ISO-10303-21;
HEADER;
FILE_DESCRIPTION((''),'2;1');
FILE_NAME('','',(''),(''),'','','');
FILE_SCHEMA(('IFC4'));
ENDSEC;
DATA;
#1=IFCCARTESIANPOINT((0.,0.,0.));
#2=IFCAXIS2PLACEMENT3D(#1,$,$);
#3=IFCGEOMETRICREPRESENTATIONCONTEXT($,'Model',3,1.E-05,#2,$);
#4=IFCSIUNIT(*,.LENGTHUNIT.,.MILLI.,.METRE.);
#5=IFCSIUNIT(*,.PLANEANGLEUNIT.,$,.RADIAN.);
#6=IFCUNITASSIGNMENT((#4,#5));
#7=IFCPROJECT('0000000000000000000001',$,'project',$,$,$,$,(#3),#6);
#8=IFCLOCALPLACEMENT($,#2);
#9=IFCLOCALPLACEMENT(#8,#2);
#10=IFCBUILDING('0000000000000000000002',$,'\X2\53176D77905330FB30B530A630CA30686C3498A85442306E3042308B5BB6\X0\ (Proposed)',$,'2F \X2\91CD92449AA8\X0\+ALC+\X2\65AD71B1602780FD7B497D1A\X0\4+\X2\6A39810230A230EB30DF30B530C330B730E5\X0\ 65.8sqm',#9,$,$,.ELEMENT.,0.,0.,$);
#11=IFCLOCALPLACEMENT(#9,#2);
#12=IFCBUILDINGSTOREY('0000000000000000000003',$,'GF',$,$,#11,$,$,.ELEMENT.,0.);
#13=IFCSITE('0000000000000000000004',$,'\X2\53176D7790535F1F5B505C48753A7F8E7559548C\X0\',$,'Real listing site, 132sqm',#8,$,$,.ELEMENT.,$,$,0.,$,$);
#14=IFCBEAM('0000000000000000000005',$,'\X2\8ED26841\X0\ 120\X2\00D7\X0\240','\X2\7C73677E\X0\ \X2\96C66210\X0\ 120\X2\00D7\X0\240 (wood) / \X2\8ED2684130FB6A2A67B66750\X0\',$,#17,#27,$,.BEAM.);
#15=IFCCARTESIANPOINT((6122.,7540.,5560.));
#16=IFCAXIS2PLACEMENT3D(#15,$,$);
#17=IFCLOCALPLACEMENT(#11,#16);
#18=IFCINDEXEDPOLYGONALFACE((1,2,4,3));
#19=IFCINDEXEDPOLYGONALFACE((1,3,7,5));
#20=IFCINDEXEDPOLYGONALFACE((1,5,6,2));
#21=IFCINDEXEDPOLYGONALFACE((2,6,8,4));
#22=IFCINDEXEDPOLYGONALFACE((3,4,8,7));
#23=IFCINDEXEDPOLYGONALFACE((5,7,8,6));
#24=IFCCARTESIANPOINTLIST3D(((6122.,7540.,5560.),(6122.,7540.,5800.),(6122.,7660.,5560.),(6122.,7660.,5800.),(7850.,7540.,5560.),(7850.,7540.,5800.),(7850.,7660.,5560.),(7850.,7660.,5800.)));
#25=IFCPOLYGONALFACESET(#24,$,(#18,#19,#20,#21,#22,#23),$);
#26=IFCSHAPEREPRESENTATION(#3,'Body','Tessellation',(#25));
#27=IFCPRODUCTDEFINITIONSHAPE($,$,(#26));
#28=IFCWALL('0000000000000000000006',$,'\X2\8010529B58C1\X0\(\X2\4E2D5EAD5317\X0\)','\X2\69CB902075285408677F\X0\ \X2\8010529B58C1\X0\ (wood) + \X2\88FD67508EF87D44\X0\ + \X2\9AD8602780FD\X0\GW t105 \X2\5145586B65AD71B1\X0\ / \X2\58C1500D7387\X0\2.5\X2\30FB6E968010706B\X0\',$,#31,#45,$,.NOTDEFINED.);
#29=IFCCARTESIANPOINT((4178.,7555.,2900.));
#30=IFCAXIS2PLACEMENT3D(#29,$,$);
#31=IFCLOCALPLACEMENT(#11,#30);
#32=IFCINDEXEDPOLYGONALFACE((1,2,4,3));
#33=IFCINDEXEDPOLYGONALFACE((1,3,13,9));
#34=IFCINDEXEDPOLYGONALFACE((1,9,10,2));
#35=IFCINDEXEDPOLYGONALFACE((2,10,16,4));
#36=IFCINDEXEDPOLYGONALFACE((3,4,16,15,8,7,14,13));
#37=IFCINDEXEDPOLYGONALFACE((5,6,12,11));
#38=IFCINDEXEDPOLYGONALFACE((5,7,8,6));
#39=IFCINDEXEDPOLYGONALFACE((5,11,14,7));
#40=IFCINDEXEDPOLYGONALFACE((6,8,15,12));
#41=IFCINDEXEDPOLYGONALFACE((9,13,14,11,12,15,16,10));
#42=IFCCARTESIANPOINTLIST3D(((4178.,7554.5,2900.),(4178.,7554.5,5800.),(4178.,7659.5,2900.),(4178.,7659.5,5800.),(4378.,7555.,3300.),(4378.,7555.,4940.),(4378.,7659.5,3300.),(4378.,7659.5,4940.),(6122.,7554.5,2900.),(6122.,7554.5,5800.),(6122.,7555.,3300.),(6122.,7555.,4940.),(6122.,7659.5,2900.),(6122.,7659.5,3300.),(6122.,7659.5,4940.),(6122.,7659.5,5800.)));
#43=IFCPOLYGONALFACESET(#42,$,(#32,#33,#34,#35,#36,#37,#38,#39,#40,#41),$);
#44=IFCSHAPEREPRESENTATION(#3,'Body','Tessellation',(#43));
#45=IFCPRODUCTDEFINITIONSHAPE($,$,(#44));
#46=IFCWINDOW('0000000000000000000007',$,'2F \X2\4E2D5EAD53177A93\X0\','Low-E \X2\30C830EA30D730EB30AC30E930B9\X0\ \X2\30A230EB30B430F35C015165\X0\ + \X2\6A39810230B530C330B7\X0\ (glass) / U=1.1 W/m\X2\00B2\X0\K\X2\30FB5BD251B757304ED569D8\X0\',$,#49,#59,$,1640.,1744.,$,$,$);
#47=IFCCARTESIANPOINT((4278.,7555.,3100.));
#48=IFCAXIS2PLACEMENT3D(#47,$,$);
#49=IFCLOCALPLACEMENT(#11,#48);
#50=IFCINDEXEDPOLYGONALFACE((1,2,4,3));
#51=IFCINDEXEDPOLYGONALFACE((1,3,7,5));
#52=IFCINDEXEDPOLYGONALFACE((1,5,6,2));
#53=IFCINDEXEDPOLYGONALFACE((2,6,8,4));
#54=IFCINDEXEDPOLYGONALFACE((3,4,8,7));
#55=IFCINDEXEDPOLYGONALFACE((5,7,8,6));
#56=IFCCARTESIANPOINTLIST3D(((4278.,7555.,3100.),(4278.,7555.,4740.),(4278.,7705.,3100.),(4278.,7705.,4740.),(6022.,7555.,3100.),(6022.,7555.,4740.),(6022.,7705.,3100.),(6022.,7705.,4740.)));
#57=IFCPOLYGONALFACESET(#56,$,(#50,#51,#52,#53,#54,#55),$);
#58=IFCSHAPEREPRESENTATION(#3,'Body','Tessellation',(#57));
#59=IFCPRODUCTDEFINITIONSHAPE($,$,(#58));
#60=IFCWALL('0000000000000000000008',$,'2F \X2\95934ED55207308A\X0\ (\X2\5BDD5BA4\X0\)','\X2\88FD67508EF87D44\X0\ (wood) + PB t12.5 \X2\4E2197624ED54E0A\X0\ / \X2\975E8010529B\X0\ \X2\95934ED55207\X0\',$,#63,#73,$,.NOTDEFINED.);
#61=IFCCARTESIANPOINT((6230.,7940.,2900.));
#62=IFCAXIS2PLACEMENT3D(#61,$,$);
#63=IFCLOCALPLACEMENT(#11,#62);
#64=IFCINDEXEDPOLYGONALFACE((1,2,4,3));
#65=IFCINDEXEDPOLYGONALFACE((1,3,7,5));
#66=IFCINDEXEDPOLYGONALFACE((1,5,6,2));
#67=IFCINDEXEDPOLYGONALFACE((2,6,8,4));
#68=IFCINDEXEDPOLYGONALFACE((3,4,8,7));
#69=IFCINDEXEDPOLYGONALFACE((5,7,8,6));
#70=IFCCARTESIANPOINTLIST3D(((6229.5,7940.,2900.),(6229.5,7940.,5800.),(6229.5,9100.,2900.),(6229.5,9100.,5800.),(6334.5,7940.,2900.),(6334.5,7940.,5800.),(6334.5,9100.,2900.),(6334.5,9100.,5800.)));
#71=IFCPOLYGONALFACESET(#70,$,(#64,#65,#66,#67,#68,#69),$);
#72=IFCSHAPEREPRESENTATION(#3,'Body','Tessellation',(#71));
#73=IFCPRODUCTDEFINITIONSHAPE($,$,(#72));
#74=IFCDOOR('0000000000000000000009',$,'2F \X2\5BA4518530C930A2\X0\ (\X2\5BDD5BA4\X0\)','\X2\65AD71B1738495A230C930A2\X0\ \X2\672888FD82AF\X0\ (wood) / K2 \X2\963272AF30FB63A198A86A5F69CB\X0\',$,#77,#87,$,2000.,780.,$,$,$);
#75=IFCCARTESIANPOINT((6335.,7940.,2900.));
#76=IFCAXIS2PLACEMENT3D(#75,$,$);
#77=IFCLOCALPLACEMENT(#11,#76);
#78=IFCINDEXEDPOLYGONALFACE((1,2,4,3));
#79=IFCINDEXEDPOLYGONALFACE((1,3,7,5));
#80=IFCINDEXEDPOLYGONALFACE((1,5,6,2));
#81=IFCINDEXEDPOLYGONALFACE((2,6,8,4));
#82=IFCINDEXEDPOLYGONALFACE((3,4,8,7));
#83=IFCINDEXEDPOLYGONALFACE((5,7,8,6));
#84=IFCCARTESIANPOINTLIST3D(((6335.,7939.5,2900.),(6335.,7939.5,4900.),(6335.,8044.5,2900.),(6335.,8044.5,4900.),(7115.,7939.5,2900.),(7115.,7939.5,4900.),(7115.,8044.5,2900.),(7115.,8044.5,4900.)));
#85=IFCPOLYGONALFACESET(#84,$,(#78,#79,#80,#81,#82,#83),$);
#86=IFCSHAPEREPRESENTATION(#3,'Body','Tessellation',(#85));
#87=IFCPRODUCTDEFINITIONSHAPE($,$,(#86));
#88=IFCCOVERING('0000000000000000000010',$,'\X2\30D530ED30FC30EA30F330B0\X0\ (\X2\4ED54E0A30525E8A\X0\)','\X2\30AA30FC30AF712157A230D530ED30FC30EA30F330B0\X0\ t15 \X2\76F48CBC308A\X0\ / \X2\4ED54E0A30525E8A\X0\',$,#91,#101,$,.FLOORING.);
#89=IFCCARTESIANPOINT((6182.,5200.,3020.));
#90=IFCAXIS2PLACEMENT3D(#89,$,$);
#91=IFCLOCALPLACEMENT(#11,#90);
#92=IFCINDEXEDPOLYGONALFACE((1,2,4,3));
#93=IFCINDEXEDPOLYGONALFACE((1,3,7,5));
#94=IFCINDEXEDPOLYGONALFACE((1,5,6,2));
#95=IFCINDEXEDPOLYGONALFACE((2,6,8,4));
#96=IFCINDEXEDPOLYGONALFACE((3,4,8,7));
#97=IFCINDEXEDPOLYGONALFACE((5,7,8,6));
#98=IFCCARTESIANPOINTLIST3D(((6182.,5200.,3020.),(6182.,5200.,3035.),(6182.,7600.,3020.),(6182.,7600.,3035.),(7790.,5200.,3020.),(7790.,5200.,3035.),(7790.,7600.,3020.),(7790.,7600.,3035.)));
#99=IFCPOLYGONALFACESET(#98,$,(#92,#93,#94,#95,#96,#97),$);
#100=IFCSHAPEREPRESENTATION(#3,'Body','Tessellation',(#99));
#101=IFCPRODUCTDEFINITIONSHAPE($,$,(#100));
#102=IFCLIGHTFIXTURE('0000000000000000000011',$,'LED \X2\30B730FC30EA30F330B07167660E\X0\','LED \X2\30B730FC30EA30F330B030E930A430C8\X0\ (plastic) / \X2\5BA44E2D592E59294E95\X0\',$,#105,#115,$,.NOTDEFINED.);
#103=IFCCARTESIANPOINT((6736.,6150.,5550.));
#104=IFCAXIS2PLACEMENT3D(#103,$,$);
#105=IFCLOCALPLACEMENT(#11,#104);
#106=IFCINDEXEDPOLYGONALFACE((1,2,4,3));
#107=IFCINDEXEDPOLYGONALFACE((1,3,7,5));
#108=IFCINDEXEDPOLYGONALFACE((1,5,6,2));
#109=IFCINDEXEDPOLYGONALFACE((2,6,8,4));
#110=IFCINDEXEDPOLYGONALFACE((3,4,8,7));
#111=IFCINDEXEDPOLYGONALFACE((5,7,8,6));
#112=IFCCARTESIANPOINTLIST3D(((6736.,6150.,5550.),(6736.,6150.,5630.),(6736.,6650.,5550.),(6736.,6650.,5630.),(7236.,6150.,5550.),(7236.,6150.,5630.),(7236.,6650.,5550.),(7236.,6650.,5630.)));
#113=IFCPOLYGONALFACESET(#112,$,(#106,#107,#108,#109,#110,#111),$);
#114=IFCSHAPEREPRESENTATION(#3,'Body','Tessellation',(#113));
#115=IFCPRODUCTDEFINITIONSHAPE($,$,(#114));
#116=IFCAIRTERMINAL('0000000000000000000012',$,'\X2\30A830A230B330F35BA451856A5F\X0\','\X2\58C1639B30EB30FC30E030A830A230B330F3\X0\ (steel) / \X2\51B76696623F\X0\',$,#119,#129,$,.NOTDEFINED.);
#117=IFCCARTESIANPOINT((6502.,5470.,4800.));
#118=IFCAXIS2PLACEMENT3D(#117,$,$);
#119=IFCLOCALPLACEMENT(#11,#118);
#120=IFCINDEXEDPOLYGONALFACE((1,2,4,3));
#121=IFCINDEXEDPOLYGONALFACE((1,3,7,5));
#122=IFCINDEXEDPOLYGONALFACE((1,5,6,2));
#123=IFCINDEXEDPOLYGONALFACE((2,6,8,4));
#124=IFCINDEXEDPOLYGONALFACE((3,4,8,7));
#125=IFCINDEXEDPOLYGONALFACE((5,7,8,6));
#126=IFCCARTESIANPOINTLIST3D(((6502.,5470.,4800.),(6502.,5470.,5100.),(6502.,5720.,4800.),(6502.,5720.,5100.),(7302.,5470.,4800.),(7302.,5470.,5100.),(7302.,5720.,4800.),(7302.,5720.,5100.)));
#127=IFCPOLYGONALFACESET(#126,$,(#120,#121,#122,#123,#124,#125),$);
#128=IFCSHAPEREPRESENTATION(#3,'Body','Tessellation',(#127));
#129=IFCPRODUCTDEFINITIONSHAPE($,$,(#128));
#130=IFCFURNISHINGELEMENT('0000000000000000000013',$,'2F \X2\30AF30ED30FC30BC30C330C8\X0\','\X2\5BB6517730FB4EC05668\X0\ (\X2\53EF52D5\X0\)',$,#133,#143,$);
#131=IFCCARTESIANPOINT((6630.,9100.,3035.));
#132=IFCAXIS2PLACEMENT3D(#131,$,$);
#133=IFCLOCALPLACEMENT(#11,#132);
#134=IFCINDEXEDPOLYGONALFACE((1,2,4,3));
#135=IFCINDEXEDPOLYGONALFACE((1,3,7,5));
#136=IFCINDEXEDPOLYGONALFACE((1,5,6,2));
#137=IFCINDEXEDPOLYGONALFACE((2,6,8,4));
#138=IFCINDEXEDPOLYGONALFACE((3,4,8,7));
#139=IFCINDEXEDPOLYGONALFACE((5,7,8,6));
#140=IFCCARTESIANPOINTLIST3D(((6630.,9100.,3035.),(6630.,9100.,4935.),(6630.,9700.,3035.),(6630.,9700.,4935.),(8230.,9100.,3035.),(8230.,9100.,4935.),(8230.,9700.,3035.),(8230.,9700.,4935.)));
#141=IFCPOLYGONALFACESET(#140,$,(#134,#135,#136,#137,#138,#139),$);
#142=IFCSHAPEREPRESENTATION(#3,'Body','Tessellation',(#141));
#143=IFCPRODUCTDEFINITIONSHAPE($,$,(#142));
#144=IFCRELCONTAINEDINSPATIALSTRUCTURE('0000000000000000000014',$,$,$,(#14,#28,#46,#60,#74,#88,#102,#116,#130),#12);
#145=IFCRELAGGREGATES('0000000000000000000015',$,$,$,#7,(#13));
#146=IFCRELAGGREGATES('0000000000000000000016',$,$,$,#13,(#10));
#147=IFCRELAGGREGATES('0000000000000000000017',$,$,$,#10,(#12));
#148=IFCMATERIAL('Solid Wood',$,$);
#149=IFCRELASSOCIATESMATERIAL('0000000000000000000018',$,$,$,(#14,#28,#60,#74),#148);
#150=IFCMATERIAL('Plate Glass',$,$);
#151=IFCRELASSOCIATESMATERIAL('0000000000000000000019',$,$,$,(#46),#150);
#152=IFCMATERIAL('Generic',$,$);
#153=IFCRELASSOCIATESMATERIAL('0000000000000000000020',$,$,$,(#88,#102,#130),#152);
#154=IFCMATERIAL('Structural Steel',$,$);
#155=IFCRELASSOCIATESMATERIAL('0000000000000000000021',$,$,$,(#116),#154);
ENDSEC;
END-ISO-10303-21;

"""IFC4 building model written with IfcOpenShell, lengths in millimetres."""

from ifc_helpers import new_model, si_unit, frame, frame_2d, origin, place, context, project, spatial, rectangle, extrude, material, element, fill, save


model = new_model("IFC4")

# Units and contexts
model_context = context("Model", 3, precision=1e-05, world=origin())
ifc_project = project(units=[si_unit("LENGTHUNIT", "METRE", prefix="MILLI"), si_unit("PLANEANGLEUNIT", "RADIAN")], contexts=[model_context])

# Site, building, storey
site_placement = place(None, origin())
site = spatial("IfcSite", under=ifc_project, at=site_placement, Name="北海道弟子屈町美留和", ObjectType="Real listing site, 132sqm", CompositionType="ELEMENT", RefElevation=0.0)
building_placement = place(site_placement, origin())
building = spatial("IfcBuilding", under=site, at=building_placement, Name="北海道・サウナと水風呂のある家 (Proposed)", ObjectType="2F 重鉄骨+ALC+断熱性能等級4+樹脂アルミサッシュ 65.8sqm", CompositionType="ELEMENT", ElevationOfRefHeight=0.0, ElevationOfTerrain=0.0)
storey_placement = place(building_placement, origin())
storey = spatial("IfcBuildingStorey", under=building, at=storey_placement, Name="GF", CompositionType="ELEMENT", Elevation=0.0)

# Shared definitions
ifc_material_1 = material(Name="Solid Wood")

# Beam
beam_1_placement = place(storey_placement, frame((6122.0, 7540.0, 5560.0)))
element("IfcBeam", 1, at=beam_1_placement, inside=storey, material=ifc_material_1, Name="軒桁 120×240", Description="米松 集成 120×240 (wood) / 軒桁・横架材", PredefinedType="BEAM", context=model_context, shape_type="SweptSolid", body=[
    extrude(rectangle(XDim=1728.0, YDim=120.0, at=frame_2d((864.0, 60.0))), frame((6122.0, 7540.0, 5560.0)), (0.0, 0.0, 1.0), 240.0),
])

# Wall, opening, window
wall_1_placement = place(storey_placement, frame((4178.0, 7555.0, 2900.0)))
wall_1 = element("IfcWall", 2, at=wall_1_placement, inside=storey, material=ifc_material_1, Name="耐力壁(中庭北)", Description="構造用合板 耐力壁 (wood) + 製材軸組 + 高性能GW t105 充填断熱 / 壁倍率2.5・準耐火", PredefinedType="NOTDEFINED", context=model_context, shape_type="SweptSolid", body=[
    extrude(rectangle(XDim=1944.0, YDim=105.0, at=frame_2d((972.0, 52.0))), frame((4178.0, 7555.0, 2900.0)), (0.0, 0.0, 1.0), 2900.0),
])
opening_placement = place(storey_placement, frame((4278.0, 7555.0, 3100.0)))
opening = element("IfcOpeningElement", 3, at=opening_placement, cuts=wall_1, PredefinedType="NOTDEFINED", context=model_context, shape_type="SweptSolid", body=[
    extrude(rectangle(XDim=1744.0, YDim=150.0, at=frame_2d((872.0, 75.0))), frame((4278.0, 7555.0, 3100.0)), (0.0, 0.0, 1.0), 1640.0),
])
ifc_material_2 = material(Name="Plate Glass")
window_placement = place(storey_placement, frame((4278.0, 7555.0, 3100.0)))
window = element("IfcWindow", 4, at=window_placement, inside=storey, material=ifc_material_2, Name="2F 中庭北窓", Description="Low-E トリプルガラス アルゴン封入 + 樹脂サッシ (glass) / U=1.1 W/m²K・寒冷地仕様", OverallHeight=1640.0, OverallWidth=1744.0, context=model_context, shape_type="SweptSolid", body=[
    extrude(rectangle(XDim=1744.0, YDim=150.0, at=frame_2d((872.0, 75.0))), frame((4278.0, 7555.0, 3100.0)), (0.0, 0.0, 1.0), 1640.0),
])
fill(opening, window)

# Wall
wall_2_placement = place(storey_placement, frame((6230.0, 7940.0, 2900.0)))
element("IfcWall", 5, at=wall_2_placement, inside=storey, material=ifc_material_1, Name="2F 間仕切り (寝室)", Description="製材軸組 (wood) + PB t12.5 両面仕上 / 非耐力 間仕切", PredefinedType="NOTDEFINED", context=model_context, shape_type="SweptSolid", body=[
    extrude(rectangle(XDim=105.0, YDim=1160.0, at=frame_2d((52.0, 580.0))), frame((6230.0, 7940.0, 2900.0)), (0.0, 0.0, 1.0), 2900.0),
])

# Door
door_placement = place(storey_placement, frame((6335.0, 7940.0, 2900.0)))
element("IfcDoor", 6, at=door_placement, inside=storey, material=ifc_material_1, Name="2F 室内ドア (寝室)", Description="断熱玄関ドア 木製芯 (wood) / K2 防犯・採風機構", OverallHeight=2000.0, OverallWidth=780.0, context=model_context, shape_type="SweptSolid", body=[
    extrude(rectangle(XDim=780.0, YDim=105.0, at=frame_2d((390.0, 52.0))), frame((6335.0, 7940.0, 2900.0)), (0.0, 0.0, 1.0), 2000.0),
])

# Covering
ifc_material_3 = material(Name="Generic")
covering_placement = place(storey_placement, frame((6182.0, 5200.0, 3020.0)))
element("IfcCovering", 7, at=covering_placement, inside=storey, material=ifc_material_3, Name="フローリング (仕上げ床)", Description="オーク無垢フローリング t15 直貼り / 仕上げ床", PredefinedType="FLOORING", context=model_context, shape_type="SweptSolid", body=[
    extrude(rectangle(XDim=1608.0, YDim=2400.0, at=frame_2d((804.0, 1200.0))), frame((6182.0, 5200.0, 3020.0)), (0.0, 0.0, 1.0), 15.0),
])

# Light fixture
light_fixture_placement = place(storey_placement, frame((6736.0, 6150.0, 5550.0)))
element("IfcLightFixture", 8, at=light_fixture_placement, inside=storey, material=ifc_material_3, Name="LED シーリング照明", Description="LED シーリングライト (plastic) / 室中央天井", PredefinedType="NOTDEFINED", context=model_context, shape_type="SweptSolid", body=[
    extrude(rectangle(XDim=500.0, YDim=500.0, at=frame_2d((250.0, 250.0))), frame((6736.0, 6150.0, 5550.0)), (0.0, 0.0, 1.0), 80.0),
])

# Air terminal
ifc_material_4 = material(Name="Structural Steel")
air_terminal_placement = place(storey_placement, frame((6502.0, 5470.0, 4800.0)))
element("IfcAirTerminal", 9, at=air_terminal_placement, inside=storey, material=ifc_material_4, Name="エアコン室内機", Description="壁掛ルームエアコン (steel) / 冷暖房", PredefinedType="NOTDEFINED", context=model_context, shape_type="SweptSolid", body=[
    extrude(rectangle(XDim=800.0, YDim=250.0, at=frame_2d((400.0, 125.0))), frame((6502.0, 5470.0, 4800.0)), (0.0, 0.0, 1.0), 300.0),
])

# Furnishing element
furnishing_placement = place(storey_placement, frame((6630.0, 9100.0, 3035.0)))
element("IfcFurnishingElement", 10, at=furnishing_placement, inside=storey, material=ifc_material_3, Name="2F クローゼット", Description="家具・什器 (可動)", context=model_context, shape_type="SweptSolid", body=[
    extrude(rectangle(XDim=1600.0, YDim=600.0, at=frame_2d((800.0, 300.0))), frame((6630.0, 9100.0, 3035.0)), (0.0, 0.0, 1.0), 1900.0),
])

save(model, "model.ifc")
